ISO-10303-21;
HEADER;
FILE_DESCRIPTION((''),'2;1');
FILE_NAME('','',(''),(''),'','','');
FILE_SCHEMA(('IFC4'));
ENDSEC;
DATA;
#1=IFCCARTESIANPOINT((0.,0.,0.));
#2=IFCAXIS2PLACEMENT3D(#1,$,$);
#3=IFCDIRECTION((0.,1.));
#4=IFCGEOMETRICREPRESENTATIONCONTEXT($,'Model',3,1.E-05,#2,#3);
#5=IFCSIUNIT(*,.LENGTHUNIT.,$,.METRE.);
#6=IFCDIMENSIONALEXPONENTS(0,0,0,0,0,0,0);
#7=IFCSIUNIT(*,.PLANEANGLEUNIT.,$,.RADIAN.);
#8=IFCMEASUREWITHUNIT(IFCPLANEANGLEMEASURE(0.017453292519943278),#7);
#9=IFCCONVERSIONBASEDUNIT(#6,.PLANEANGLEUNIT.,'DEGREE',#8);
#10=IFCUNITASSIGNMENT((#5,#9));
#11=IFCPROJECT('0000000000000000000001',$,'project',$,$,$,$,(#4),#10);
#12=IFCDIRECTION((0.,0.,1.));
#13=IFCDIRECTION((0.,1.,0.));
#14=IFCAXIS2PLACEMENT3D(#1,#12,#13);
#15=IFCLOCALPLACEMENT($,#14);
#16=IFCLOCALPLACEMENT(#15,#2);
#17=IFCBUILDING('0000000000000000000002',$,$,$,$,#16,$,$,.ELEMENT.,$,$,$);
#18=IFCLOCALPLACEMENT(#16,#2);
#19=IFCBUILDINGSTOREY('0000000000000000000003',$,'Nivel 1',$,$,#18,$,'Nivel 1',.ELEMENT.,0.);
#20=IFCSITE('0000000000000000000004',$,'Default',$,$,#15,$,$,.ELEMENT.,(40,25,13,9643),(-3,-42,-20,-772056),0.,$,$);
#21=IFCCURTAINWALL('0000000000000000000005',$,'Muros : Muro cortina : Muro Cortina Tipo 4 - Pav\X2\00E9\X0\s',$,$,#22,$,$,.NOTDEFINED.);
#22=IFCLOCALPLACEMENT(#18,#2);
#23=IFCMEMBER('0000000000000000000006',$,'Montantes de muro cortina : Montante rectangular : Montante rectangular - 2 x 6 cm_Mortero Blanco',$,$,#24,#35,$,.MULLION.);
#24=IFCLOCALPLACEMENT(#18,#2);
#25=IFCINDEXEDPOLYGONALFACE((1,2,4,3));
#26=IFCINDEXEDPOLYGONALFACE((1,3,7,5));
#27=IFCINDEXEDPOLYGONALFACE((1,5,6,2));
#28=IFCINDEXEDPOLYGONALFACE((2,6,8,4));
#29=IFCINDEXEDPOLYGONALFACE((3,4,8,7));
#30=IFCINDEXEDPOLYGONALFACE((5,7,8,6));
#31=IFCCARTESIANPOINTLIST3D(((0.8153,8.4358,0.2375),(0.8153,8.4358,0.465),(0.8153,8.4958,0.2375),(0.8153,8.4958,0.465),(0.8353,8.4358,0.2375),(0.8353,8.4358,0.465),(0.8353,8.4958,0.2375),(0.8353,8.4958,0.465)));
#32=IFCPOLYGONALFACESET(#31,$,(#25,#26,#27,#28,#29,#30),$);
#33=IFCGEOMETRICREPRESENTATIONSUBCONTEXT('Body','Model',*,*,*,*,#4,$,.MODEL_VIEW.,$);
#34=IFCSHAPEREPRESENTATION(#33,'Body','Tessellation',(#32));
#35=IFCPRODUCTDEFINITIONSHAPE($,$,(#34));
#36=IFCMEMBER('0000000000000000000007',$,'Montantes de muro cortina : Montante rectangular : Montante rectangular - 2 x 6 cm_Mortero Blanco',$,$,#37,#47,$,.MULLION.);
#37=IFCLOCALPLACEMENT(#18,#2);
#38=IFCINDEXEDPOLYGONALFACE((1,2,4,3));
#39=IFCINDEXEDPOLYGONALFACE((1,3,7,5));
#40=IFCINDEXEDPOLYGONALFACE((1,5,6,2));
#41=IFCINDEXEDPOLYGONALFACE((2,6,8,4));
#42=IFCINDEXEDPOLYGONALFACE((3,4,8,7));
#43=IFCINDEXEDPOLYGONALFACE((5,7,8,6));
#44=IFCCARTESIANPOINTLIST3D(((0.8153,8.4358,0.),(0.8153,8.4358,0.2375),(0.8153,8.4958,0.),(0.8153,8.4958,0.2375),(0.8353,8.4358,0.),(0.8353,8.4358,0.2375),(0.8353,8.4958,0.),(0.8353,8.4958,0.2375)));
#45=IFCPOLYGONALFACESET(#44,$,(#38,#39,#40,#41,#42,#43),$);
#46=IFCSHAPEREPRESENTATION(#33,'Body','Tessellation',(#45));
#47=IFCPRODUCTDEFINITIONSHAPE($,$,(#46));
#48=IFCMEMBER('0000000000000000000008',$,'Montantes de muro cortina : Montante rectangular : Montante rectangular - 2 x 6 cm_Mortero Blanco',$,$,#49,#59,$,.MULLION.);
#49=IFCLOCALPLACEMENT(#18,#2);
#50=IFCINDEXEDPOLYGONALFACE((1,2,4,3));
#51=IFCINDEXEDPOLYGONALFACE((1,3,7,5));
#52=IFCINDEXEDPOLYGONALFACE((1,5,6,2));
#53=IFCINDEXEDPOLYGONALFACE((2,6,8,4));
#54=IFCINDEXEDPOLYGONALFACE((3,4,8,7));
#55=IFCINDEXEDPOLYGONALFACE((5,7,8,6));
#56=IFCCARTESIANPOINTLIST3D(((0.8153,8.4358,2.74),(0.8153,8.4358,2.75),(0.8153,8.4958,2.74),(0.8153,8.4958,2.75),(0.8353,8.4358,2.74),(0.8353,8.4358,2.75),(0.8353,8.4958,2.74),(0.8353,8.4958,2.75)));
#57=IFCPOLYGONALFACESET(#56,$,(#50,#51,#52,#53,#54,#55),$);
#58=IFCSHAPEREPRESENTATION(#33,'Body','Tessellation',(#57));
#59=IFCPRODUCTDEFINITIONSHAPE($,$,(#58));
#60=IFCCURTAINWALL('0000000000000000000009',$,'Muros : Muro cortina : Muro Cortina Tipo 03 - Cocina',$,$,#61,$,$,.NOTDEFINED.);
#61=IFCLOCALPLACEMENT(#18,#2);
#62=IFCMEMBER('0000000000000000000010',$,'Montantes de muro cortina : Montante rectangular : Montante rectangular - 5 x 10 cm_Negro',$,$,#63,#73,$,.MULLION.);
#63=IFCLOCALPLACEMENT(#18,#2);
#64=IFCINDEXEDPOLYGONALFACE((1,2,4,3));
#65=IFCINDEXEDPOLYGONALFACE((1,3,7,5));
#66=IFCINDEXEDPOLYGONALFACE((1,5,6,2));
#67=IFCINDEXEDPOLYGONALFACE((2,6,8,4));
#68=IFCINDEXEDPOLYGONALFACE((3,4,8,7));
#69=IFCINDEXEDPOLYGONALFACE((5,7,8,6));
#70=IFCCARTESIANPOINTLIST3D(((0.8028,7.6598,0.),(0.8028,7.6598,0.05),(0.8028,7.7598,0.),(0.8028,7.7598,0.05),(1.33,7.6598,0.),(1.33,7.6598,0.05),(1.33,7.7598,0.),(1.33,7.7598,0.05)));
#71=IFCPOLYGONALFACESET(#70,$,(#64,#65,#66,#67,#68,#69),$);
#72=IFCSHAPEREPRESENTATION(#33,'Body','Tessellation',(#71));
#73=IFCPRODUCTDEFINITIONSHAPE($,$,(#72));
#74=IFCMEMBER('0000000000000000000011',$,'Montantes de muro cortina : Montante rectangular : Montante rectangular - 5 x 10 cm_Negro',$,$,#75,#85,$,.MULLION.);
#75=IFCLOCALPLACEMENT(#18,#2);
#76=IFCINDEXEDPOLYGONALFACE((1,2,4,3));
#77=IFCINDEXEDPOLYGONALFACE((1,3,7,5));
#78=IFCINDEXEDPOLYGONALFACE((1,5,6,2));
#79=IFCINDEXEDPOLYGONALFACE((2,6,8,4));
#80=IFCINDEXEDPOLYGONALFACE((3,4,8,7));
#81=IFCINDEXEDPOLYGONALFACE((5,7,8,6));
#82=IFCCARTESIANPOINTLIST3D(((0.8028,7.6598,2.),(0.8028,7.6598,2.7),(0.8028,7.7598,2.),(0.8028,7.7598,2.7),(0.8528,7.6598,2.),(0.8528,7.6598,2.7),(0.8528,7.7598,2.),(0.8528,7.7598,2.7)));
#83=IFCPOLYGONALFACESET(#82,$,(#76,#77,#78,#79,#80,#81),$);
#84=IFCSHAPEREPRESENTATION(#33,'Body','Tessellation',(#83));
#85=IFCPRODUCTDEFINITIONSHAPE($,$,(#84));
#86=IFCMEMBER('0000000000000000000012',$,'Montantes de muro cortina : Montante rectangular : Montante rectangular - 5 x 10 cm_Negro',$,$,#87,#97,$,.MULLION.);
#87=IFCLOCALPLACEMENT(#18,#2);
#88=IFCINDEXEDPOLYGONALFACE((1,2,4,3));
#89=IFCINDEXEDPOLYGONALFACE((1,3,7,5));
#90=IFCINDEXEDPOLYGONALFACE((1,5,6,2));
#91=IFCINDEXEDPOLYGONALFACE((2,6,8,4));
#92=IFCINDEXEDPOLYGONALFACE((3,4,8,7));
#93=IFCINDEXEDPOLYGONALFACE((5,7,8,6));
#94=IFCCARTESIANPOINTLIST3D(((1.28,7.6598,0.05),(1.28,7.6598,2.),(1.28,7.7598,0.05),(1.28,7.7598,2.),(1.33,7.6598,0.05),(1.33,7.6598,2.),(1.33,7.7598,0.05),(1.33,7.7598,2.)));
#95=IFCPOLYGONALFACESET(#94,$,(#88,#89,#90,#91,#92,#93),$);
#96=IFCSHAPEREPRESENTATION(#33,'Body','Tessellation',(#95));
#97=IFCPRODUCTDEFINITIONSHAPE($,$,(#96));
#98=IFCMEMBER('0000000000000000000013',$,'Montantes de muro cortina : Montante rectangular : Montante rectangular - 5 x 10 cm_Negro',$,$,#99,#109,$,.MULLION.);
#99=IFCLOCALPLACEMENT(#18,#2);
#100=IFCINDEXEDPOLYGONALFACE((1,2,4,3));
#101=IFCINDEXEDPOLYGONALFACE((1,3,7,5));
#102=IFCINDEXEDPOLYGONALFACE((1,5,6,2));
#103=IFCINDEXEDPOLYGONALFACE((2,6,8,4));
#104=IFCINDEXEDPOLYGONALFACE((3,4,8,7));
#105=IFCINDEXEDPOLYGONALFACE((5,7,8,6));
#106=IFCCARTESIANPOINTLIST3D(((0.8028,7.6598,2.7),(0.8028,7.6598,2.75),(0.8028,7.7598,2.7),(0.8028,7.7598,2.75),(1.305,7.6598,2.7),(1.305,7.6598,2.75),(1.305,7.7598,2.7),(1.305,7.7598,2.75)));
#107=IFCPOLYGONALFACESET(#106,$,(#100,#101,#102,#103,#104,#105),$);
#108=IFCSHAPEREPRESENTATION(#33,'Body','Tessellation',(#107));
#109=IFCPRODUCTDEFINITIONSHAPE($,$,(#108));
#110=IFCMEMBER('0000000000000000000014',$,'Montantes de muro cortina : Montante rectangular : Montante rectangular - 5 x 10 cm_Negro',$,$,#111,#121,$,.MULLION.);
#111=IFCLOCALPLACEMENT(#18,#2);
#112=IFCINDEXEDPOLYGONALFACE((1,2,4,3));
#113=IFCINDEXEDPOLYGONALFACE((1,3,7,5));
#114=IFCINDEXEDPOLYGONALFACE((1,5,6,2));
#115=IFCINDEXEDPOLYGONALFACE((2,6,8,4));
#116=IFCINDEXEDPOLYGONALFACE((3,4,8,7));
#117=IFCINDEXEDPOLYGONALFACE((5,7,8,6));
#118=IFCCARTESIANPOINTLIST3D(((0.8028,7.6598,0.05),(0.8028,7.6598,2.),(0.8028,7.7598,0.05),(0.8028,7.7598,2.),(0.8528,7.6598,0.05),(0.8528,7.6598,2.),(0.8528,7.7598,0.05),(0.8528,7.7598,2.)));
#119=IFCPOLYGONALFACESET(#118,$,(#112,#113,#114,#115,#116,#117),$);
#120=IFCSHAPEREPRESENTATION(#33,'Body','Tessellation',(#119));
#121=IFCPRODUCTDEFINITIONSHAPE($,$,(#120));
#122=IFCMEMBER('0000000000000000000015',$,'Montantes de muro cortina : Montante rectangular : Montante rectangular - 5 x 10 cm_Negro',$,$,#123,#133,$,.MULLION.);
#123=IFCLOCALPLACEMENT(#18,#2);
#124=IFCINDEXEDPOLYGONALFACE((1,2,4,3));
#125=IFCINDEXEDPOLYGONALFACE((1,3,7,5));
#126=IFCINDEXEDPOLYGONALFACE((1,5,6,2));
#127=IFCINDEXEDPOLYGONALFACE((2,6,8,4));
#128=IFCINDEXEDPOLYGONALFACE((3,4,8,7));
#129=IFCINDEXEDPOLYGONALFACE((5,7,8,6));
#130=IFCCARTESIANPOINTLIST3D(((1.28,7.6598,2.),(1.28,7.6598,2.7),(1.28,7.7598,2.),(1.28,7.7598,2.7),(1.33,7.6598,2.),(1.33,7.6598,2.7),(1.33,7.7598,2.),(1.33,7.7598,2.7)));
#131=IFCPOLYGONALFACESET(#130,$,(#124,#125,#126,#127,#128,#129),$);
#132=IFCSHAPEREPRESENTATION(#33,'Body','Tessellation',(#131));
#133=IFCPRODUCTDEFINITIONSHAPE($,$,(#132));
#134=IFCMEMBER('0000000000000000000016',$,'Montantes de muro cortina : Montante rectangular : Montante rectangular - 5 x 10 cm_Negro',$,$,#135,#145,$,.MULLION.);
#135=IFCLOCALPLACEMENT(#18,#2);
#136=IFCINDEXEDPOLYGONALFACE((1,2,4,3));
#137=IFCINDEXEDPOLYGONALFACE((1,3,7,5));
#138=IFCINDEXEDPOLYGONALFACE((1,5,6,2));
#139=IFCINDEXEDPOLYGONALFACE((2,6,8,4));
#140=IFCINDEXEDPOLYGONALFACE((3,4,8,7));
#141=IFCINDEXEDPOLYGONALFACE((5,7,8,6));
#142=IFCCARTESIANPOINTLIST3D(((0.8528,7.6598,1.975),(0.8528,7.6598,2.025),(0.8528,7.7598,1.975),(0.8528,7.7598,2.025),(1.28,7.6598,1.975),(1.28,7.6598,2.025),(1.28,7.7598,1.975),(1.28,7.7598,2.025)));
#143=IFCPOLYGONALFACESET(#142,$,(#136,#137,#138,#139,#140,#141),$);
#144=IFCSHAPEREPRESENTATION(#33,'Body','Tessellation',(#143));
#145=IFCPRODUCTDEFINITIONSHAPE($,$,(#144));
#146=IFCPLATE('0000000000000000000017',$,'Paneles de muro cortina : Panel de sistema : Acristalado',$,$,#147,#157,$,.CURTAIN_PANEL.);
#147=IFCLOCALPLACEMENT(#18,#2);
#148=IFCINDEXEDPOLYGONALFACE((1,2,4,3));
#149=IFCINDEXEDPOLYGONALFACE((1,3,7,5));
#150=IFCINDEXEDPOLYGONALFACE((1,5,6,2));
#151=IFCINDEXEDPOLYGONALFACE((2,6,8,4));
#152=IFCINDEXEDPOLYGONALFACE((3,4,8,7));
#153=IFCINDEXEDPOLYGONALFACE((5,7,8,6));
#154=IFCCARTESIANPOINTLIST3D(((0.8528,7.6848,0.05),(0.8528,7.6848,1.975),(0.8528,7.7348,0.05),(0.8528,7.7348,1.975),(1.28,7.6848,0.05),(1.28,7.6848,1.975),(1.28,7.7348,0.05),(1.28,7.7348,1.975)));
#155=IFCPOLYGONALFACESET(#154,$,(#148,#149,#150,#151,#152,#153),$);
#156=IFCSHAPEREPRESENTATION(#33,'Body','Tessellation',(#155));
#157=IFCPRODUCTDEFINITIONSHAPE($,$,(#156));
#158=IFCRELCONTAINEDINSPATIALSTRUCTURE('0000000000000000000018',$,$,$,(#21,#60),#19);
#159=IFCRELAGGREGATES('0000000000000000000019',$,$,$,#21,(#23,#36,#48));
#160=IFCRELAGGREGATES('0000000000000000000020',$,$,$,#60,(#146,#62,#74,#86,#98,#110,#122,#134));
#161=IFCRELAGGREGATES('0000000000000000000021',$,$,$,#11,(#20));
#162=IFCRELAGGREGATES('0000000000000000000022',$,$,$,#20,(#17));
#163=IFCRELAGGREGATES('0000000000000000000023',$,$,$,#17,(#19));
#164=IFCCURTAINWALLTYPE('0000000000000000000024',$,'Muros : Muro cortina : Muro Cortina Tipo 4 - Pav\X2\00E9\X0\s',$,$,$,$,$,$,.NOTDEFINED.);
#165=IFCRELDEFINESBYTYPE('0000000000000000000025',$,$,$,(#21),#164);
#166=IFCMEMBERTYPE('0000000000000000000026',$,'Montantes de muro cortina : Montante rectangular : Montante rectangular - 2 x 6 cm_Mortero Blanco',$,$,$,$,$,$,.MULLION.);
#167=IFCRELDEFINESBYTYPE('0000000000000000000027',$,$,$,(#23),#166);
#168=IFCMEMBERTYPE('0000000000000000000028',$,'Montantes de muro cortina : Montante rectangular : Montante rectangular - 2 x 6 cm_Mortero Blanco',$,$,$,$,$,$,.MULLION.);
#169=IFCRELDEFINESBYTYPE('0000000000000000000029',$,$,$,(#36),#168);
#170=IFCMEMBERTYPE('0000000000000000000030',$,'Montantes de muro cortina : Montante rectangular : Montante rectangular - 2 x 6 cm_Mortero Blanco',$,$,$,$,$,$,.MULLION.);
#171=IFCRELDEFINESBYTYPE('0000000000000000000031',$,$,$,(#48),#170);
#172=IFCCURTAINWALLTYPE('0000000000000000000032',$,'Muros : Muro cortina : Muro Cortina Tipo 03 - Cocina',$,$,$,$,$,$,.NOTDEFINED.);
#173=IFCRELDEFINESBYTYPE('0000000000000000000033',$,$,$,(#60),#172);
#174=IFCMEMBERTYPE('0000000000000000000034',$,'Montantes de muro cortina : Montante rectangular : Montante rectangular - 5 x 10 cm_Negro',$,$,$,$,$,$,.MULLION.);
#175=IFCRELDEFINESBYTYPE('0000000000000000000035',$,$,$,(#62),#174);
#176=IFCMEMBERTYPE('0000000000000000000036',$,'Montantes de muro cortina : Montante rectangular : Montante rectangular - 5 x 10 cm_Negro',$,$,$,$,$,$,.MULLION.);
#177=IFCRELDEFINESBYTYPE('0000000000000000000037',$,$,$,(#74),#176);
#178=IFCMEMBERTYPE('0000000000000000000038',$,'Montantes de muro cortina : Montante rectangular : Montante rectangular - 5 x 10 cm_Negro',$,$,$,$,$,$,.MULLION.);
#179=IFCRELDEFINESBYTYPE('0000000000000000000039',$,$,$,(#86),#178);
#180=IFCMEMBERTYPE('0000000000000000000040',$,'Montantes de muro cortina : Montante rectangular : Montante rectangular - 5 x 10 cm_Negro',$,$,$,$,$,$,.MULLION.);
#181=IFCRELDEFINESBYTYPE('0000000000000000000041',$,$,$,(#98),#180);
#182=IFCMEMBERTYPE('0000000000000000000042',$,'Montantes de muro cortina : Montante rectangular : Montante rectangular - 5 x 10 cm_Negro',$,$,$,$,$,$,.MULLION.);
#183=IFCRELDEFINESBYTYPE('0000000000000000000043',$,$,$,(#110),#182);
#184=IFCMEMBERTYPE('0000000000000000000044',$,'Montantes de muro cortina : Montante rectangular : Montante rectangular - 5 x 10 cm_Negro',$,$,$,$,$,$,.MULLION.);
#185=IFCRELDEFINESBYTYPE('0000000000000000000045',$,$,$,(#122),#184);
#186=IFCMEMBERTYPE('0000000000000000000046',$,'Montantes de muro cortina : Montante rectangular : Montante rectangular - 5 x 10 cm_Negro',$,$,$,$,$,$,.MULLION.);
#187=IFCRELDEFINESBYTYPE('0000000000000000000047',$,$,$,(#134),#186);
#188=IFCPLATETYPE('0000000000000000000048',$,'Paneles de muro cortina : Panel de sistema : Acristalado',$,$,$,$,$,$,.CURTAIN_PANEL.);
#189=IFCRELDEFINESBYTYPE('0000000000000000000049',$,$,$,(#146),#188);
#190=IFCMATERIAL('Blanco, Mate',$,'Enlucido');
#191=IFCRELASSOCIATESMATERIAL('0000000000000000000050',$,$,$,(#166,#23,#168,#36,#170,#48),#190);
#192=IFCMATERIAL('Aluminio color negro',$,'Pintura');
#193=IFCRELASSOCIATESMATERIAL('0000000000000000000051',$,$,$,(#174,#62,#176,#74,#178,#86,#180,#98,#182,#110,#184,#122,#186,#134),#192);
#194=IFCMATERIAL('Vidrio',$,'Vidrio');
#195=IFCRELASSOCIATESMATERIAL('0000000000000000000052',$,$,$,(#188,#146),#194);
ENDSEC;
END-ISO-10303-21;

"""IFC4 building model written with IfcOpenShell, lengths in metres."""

from ifc_helpers import new_model, entity, si_unit, converted_unit, direction, frame, origin, place, context, subcontext, project, spatial, indexed_curve, outline, extrude, source, transform, mapped, material, type_object, type_shapes, element, aggregate, save


model = new_model("IFC4")

# Units and contexts
model_context = context("Model", 3, precision=1e-05, world=origin(), true_north=direction((0.0, 1.0)))
body_context = subcontext(model_context, "Body", "Model", "MODEL_VIEW")
ifc_project = project(units=[si_unit("LENGTHUNIT", "METRE"), converted_unit("PLANEANGLEUNIT", "DEGREE", entity("IfcPlaneAngleMeasure", 0.017453292519943278), si_unit("PLANEANGLEUNIT", "RADIAN"), dimensions=[0, 0, 0, 0, 0, 0, 0])], contexts=[model_context])

# Site, building, storey
site_placement = place(None, frame((0.0, 0.0, 0.0), z_axis=(0.0, 0.0, 1.0), x_axis=(0.0, 1.0, 0.0)))
site = spatial("IfcSite", under=ifc_project, at=site_placement, Name="Default", CompositionType="ELEMENT", RefLatitude=(40, 25, 13, 9643), RefLongitude=(-3, -42, -20, -772056), RefElevation=0.0)
building_placement = place(site_placement, origin())
building = spatial("IfcBuilding", under=site, at=building_placement, CompositionType="ELEMENT")
storey_placement = place(building_placement, origin())
storey = spatial("IfcBuildingStorey", under=building, at=storey_placement, Name="Nivel 1", LongName="Nivel 1", CompositionType="ELEMENT", Elevation=0.0)

# Curtain wall, members
curtain_wall_type_1 = type_object("IfcCurtainWallType", Name="Muros : Muro cortina : Muro Cortina Tipo 4 - Pavés", PredefinedType="NOTDEFINED")
curtain_wall_1_placement = place(storey_placement, origin())
curtain_wall_1 = element("IfcCurtainWall", 1, at=curtain_wall_1_placement, inside=storey, type_object=curtain_wall_type_1, Name="Muros : Muro cortina : Muro Cortina Tipo 4 - Pavés", PredefinedType="NOTDEFINED")
ifc_material_1 = material(Name="Blanco, Mate", Category="Enlucido")
member_type_1 = type_object("IfcMemberType", Name="Montantes de muro cortina : Montante rectangular : Montante rectangular - 2 x 6 cm_Mortero Blanco", PredefinedType="MULLION", material=ifc_material_1)
shared_shape_1 = source(origin(), body_context, "Body", "SweptSolid", [
    extrude(outline(indexed_curve([(-0.01, -0.03), (0.01, -0.03), (0.01, 0.03), (-0.01, 0.03), (-0.01, -0.03)], self_intersect=False)), frame((-0.01, 0.0, -0.2275), z_axis=(0.0, 0.0, 1.0), x_axis=(-1.0, 0.0, 0.0)), (0.0, 0.0, 1.0), 0.2275),
])
type_shapes(member_type_1, [shared_shape_1])
member_1_placement = place(curtain_wall_1_placement, frame((0.8353, 8.4658, 0.465)))
member_1 = element("IfcMember", 2, at=member_1_placement, type_object=member_type_1, material=ifc_material_1, Name="Montantes de muro cortina : Montante rectangular : Montante rectangular - 2 x 6 cm_Mortero Blanco", PredefinedType="MULLION", context=body_context, shape_type="MappedRepresentation", body=[
    mapped(shared_shape_1, transform((0.0, 0.0, 0.0), scale=1.0)),
])
member_type_2 = type_object("IfcMemberType", Name="Montantes de muro cortina : Montante rectangular : Montante rectangular - 2 x 6 cm_Mortero Blanco", PredefinedType="MULLION", material=ifc_material_1)
shared_shape_2 = source(origin(), body_context, "Body", "SweptSolid", [
    extrude(outline(indexed_curve([(-0.01, -0.03), (0.01, -0.03), (0.01, 0.03), (-0.01, 0.03), (-0.01, -0.03)], self_intersect=False)), frame((-0.01, 0.0, -0.2375), z_axis=(0.0, 0.0, 1.0), x_axis=(-1.0, 0.0, 0.0)), (0.0, 0.0, 1.0), 0.2375),
])
type_shapes(member_type_2, [shared_shape_2])
member_2_placement = place(curtain_wall_1_placement, frame((0.8353, 8.4658, 0.2375)))
member_2 = element("IfcMember", 3, at=member_2_placement, type_object=member_type_2, material=ifc_material_1, Name="Montantes de muro cortina : Montante rectangular : Montante rectangular - 2 x 6 cm_Mortero Blanco", PredefinedType="MULLION", context=body_context, shape_type="MappedRepresentation", body=[
    mapped(shared_shape_2, transform((0.0, 0.0, 0.0), scale=1.0)),
])
member_type_3 = type_object("IfcMemberType", Name="Montantes de muro cortina : Montante rectangular : Montante rectangular - 2 x 6 cm_Mortero Blanco", PredefinedType="MULLION", material=ifc_material_1)
shared_shape_3 = source(origin(), body_context, "Body", "SweptSolid", [
    extrude(outline(indexed_curve([(-0.01, -0.03), (0.01, -0.03), (0.01, 0.03), (-0.01, 0.03), (-0.01, -0.03)], self_intersect=False)), frame((-0.01, 0.0, -0.01), z_axis=(0.0, 0.0, 1.0), x_axis=(-1.0, 0.0, 0.0)), (0.0, 0.0, 1.0), 0.01),
])
type_shapes(member_type_3, [shared_shape_3])
member_3_placement = place(curtain_wall_1_placement, frame((0.8353, 8.4658, 2.75)))
member_3 = element("IfcMember", 4, at=member_3_placement, type_object=member_type_3, material=ifc_material_1, Name="Montantes de muro cortina : Montante rectangular : Montante rectangular - 2 x 6 cm_Mortero Blanco", PredefinedType="MULLION", context=body_context, shape_type="MappedRepresentation", body=[
    mapped(shared_shape_3, transform((0.0, 0.0, 0.0), scale=1.0)),
])
aggregate(curtain_wall_1, [member_1, member_2, member_3])

# Curtain wall, members, plate
curtain_wall_type_2 = type_object("IfcCurtainWallType", Name="Muros : Muro cortina : Muro Cortina Tipo 03 - Cocina", PredefinedType="NOTDEFINED")
curtain_wall_2_placement = place(storey_placement, origin())
curtain_wall_2 = element("IfcCurtainWall", 5, at=curtain_wall_2_placement, inside=storey, type_object=curtain_wall_type_2, Name="Muros : Muro cortina : Muro Cortina Tipo 03 - Cocina", PredefinedType="NOTDEFINED")
ifc_material_2 = material(Name="Aluminio color negro", Category="Pintura")
member_type_4 = type_object("IfcMemberType", Name="Montantes de muro cortina : Montante rectangular : Montante rectangular - 5 x 10 cm_Negro", PredefinedType="MULLION", material=ifc_material_2)
shared_shape_4 = source(origin(), body_context, "Body", "SweptSolid", [
    extrude(outline(indexed_curve([(-0.05, -0.025), (0.05, -0.025), (0.05, 0.025), (-0.05, 0.025), (-0.05, -0.025)], self_intersect=False)), frame((-0.025, 0.0, -0.5272), z_axis=(0.0, 0.0, 1.0), x_axis=(0.0, -1.0, 0.0)), (0.0, 0.0, 1.0), 0.5272),
])
type_shapes(member_type_4, [shared_shape_4])
member_4_placement = place(curtain_wall_2_placement, frame((0.8028, 7.7098, 0.0), z_axis=(-1.0, 0.0, 0.0), x_axis=(0.0, 0.0, -1.0)))
member_4 = element("IfcMember", 6, at=member_4_placement, type_object=member_type_4, material=ifc_material_2, Name="Montantes de muro cortina : Montante rectangular : Montante rectangular - 5 x 10 cm_Negro", PredefinedType="MULLION", context=body_context, shape_type="MappedRepresentation", body=[
    mapped(shared_shape_4, transform((0.0, 0.0, 0.0), scale=1.0)),
])
member_type_5 = type_object("IfcMemberType", Name="Montantes de muro cortina : Montante rectangular : Montante rectangular - 5 x 10 cm_Negro", PredefinedType="MULLION", material=ifc_material_2)
shared_shape_5 = source(origin(), body_context, "Body", "SweptSolid", [
    extrude(outline(indexed_curve([(-0.05, -0.025), (0.05, -0.025), (0.05, 0.025), (-0.05, 0.025), (-0.05, -0.025)], self_intersect=False)), frame((-0.025, 0.0, -0.7), z_axis=(0.0, 0.0, 1.0), x_axis=(0.0, -1.0, 0.0)), (0.0, 0.0, 1.0), 0.7),
])
type_shapes(member_type_5, [shared_shape_5])
member_5_placement = place(curtain_wall_2_placement, frame((0.8028, 7.7098, 2.7), z_axis=(0.0, 0.0, 1.0), x_axis=(-1.0, 0.0, 0.0)))
member_5 = element("IfcMember", 7, at=member_5_placement, type_object=member_type_5, material=ifc_material_2, Name="Montantes de muro cortina : Montante rectangular : Montante rectangular - 5 x 10 cm_Negro", PredefinedType="MULLION", context=body_context, shape_type="MappedRepresentation", body=[
    mapped(shared_shape_5, transform((0.0, 0.0, 0.0), scale=1.0)),
])
member_type_6 = type_object("IfcMemberType", Name="Montantes de muro cortina : Montante rectangular : Montante rectangular - 5 x 10 cm_Negro", PredefinedType="MULLION", material=ifc_material_2)
shared_shape_6 = source(origin(), body_context, "Body", "SweptSolid", [
    extrude(outline(indexed_curve([(-0.025, -0.05), (0.025, -0.05), (0.025, 0.05), (-0.025, 0.05), (-0.025, -0.05)], self_intersect=False)), frame((0.0, 0.0, -1.95), z_axis=(0.0, 0.0, 1.0), x_axis=(-1.0, 0.0, 0.0)), (0.0, 0.0, 1.0), 1.95),
])
type_shapes(member_type_6, [shared_shape_6])
member_6_placement = place(curtain_wall_2_placement, frame((1.305, 7.7098, 0.05), z_axis=(0.0, 0.0, -1.0), x_axis=(1.0, 0.0, 0.0)))
member_6 = element("IfcMember", 8, at=member_6_placement, type_object=member_type_6, material=ifc_material_2, Name="Montantes de muro cortina : Montante rectangular : Montante rectangular - 5 x 10 cm_Negro", PredefinedType="MULLION", context=body_context, shape_type="MappedRepresentation", body=[
    mapped(shared_shape_6, transform((0.0, 0.0, 0.0), scale=1.0)),
])
member_type_7 = type_object("IfcMemberType", Name="Montantes de muro cortina : Montante rectangular : Montante rectangular - 5 x 10 cm_Negro", PredefinedType="MULLION", material=ifc_material_2)
shared_shape_7 = source(origin(), body_context, "Body", "SweptSolid", [
    extrude(outline(indexed_curve([(-0.025, -0.05), (0.025, -0.05), (0.025, 0.05), (-0.025, 0.05), (-0.025, -0.05)], self_intersect=False)), frame((-0.025, 0.0, -0.5022), z_axis=(0.0, 0.0, 1.0), x_axis=(-1.0, 0.0, 0.0)), (0.0, 0.0, 1.0), 0.5022),
])
type_shapes(member_type_7, [shared_shape_7])
member_7_placement = place(curtain_wall_2_placement, frame((1.305, 7.7098, 2.75), z_axis=(1.0, 0.0, 0.0), x_axis=(0.0, 0.0, 1.0)))
member_7 = element("IfcMember", 9, at=member_7_placement, type_object=member_type_7, material=ifc_material_2, Name="Montantes de muro cortina : Montante rectangular : Montante rectangular - 5 x 10 cm_Negro", PredefinedType="MULLION", context=body_context, shape_type="MappedRepresentation", body=[
    mapped(shared_shape_7, transform((0.0, 0.0, 0.0), scale=1.0)),
])
member_type_8 = type_object("IfcMemberType", Name="Montantes de muro cortina : Montante rectangular : Montante rectangular - 5 x 10 cm_Negro", PredefinedType="MULLION", material=ifc_material_2)
shared_shape_8 = source(origin(), body_context, "Body", "SweptSolid", [
    extrude(outline(indexed_curve([(-0.05, -0.025), (0.05, -0.025), (0.05, 0.025), (-0.05, 0.025), (-0.05, -0.025)], self_intersect=False)), frame((-0.025, 0.0, -1.95), z_axis=(0.0, 0.0, 1.0), x_axis=(0.0, -1.0, 0.0)), (0.0, 0.0, 1.0), 1.95),
])
type_shapes(member_type_8, [shared_shape_8])
member_8_placement = place(curtain_wall_2_placement, frame((0.8028, 7.7098, 2.0), z_axis=(0.0, 0.0, 1.0), x_axis=(-1.0, 0.0, 0.0)))
member_8 = element("IfcMember", 10, at=member_8_placement, type_object=member_type_8, material=ifc_material_2, Name="Montantes de muro cortina : Montante rectangular : Montante rectangular - 5 x 10 cm_Negro", PredefinedType="MULLION", context=body_context, shape_type="MappedRepresentation", body=[
    mapped(shared_shape_8, transform((0.0, 0.0, 0.0), scale=1.0)),
])
member_type_9 = type_object("IfcMemberType", Name="Montantes de muro cortina : Montante rectangular : Montante rectangular - 5 x 10 cm_Negro", PredefinedType="MULLION", material=ifc_material_2)
shared_shape_9 = source(origin(), body_context, "Body", "SweptSolid", [
    extrude(outline(indexed_curve([(-0.025, -0.05), (0.025, -0.05), (0.025, 0.05), (-0.025, 0.05), (-0.025, -0.05)], self_intersect=False)), frame((0.0, 0.0, -0.7), z_axis=(0.0, 0.0, 1.0), x_axis=(-1.0, 0.0, 0.0)), (0.0, 0.0, 1.0), 0.7),
])
type_shapes(member_type_9, [shared_shape_9])
member_9_placement = place(curtain_wall_2_placement, frame((1.305, 7.7098, 2.0), z_axis=(0.0, 0.0, -1.0), x_axis=(1.0, 0.0, 0.0)))
member_9 = element("IfcMember", 11, at=member_9_placement, type_object=member_type_9, material=ifc_material_2, Name="Montantes de muro cortina : Montante rectangular : Montante rectangular - 5 x 10 cm_Negro", PredefinedType="MULLION", context=body_context, shape_type="MappedRepresentation", body=[
    mapped(shared_shape_9, transform((0.0, 0.0, 0.0), scale=1.0)),
])
member_type_10 = type_object("IfcMemberType", Name="Montantes de muro cortina : Montante rectangular : Montante rectangular - 5 x 10 cm_Negro", PredefinedType="MULLION", material=ifc_material_2)
shared_shape_10 = source(origin(), body_context, "Body", "SweptSolid", [
    extrude(outline(indexed_curve([(-0.025, -0.05), (0.025, -0.05), (0.025, 0.05), (-0.025, 0.05), (-0.025, -0.05)], self_intersect=False)), frame((0.0, 0.0, -0.4272), z_axis=(0.0, 0.0, 1.0), x_axis=(-1.0, 0.0, 0.0)), (0.0, 0.0, 1.0), 0.4272),
])
type_shapes(member_type_10, [shared_shape_10])
member_10_placement = place(curtain_wall_2_placement, frame((1.28, 7.7098, 2.0), z_axis=(1.0, 0.0, 0.0), x_axis=(0.0, 0.0, 1.0)))
member_10 = element("IfcMember", 12, at=member_10_placement, type_object=member_type_10, material=ifc_material_2, Name="Montantes de muro cortina : Montante rectangular : Montante rectangular - 5 x 10 cm_Negro", PredefinedType="MULLION", context=body_context, shape_type="MappedRepresentation", body=[
    mapped(shared_shape_10, transform((0.0, 0.0, 0.0), scale=1.0)),
])
ifc_material_3 = material(Name="Vidrio", Category="Vidrio")
plate_type_1 = type_object("IfcPlateType", Name="Paneles de muro cortina : Panel de sistema : Acristalado", PredefinedType="CURTAIN_PANEL", material=ifc_material_3)
shared_shape_11 = source(origin(), body_context, "Body", "SweptSolid", [
    extrude(outline(indexed_curve([(-0.025, -0.2136), (0.025, -0.2136), (0.025, 0.2136), (-0.025, 0.2136), (-0.025, -0.2136)], self_intersect=False)), frame((0.0, 0.0, 0.0), z_axis=(0.0, 0.0, 1.0), x_axis=(0.0, 1.0, 0.0)), (0.0, 0.0, 1.0), 1.925),
])
type_shapes(plate_type_1, [shared_shape_11])
plate_1_placement = place(curtain_wall_2_placement, frame((1.0664, 7.7098, 0.05)))
plate_1 = element("IfcPlate", 13, at=plate_1_placement, type_object=plate_type_1, material=ifc_material_3, Name="Paneles de muro cortina : Panel de sistema : Acristalado", PredefinedType="CURTAIN_PANEL", context=body_context, shape_type="MappedRepresentation", body=[
    mapped(shared_shape_11, transform((0.0, 0.0, 0.0), scale=1.0)),
])

aggregate(curtain_wall_2, [plate_1, member_4, member_5, member_6, member_7, member_8, member_9, member_10])

save(model, "model.ifc")
